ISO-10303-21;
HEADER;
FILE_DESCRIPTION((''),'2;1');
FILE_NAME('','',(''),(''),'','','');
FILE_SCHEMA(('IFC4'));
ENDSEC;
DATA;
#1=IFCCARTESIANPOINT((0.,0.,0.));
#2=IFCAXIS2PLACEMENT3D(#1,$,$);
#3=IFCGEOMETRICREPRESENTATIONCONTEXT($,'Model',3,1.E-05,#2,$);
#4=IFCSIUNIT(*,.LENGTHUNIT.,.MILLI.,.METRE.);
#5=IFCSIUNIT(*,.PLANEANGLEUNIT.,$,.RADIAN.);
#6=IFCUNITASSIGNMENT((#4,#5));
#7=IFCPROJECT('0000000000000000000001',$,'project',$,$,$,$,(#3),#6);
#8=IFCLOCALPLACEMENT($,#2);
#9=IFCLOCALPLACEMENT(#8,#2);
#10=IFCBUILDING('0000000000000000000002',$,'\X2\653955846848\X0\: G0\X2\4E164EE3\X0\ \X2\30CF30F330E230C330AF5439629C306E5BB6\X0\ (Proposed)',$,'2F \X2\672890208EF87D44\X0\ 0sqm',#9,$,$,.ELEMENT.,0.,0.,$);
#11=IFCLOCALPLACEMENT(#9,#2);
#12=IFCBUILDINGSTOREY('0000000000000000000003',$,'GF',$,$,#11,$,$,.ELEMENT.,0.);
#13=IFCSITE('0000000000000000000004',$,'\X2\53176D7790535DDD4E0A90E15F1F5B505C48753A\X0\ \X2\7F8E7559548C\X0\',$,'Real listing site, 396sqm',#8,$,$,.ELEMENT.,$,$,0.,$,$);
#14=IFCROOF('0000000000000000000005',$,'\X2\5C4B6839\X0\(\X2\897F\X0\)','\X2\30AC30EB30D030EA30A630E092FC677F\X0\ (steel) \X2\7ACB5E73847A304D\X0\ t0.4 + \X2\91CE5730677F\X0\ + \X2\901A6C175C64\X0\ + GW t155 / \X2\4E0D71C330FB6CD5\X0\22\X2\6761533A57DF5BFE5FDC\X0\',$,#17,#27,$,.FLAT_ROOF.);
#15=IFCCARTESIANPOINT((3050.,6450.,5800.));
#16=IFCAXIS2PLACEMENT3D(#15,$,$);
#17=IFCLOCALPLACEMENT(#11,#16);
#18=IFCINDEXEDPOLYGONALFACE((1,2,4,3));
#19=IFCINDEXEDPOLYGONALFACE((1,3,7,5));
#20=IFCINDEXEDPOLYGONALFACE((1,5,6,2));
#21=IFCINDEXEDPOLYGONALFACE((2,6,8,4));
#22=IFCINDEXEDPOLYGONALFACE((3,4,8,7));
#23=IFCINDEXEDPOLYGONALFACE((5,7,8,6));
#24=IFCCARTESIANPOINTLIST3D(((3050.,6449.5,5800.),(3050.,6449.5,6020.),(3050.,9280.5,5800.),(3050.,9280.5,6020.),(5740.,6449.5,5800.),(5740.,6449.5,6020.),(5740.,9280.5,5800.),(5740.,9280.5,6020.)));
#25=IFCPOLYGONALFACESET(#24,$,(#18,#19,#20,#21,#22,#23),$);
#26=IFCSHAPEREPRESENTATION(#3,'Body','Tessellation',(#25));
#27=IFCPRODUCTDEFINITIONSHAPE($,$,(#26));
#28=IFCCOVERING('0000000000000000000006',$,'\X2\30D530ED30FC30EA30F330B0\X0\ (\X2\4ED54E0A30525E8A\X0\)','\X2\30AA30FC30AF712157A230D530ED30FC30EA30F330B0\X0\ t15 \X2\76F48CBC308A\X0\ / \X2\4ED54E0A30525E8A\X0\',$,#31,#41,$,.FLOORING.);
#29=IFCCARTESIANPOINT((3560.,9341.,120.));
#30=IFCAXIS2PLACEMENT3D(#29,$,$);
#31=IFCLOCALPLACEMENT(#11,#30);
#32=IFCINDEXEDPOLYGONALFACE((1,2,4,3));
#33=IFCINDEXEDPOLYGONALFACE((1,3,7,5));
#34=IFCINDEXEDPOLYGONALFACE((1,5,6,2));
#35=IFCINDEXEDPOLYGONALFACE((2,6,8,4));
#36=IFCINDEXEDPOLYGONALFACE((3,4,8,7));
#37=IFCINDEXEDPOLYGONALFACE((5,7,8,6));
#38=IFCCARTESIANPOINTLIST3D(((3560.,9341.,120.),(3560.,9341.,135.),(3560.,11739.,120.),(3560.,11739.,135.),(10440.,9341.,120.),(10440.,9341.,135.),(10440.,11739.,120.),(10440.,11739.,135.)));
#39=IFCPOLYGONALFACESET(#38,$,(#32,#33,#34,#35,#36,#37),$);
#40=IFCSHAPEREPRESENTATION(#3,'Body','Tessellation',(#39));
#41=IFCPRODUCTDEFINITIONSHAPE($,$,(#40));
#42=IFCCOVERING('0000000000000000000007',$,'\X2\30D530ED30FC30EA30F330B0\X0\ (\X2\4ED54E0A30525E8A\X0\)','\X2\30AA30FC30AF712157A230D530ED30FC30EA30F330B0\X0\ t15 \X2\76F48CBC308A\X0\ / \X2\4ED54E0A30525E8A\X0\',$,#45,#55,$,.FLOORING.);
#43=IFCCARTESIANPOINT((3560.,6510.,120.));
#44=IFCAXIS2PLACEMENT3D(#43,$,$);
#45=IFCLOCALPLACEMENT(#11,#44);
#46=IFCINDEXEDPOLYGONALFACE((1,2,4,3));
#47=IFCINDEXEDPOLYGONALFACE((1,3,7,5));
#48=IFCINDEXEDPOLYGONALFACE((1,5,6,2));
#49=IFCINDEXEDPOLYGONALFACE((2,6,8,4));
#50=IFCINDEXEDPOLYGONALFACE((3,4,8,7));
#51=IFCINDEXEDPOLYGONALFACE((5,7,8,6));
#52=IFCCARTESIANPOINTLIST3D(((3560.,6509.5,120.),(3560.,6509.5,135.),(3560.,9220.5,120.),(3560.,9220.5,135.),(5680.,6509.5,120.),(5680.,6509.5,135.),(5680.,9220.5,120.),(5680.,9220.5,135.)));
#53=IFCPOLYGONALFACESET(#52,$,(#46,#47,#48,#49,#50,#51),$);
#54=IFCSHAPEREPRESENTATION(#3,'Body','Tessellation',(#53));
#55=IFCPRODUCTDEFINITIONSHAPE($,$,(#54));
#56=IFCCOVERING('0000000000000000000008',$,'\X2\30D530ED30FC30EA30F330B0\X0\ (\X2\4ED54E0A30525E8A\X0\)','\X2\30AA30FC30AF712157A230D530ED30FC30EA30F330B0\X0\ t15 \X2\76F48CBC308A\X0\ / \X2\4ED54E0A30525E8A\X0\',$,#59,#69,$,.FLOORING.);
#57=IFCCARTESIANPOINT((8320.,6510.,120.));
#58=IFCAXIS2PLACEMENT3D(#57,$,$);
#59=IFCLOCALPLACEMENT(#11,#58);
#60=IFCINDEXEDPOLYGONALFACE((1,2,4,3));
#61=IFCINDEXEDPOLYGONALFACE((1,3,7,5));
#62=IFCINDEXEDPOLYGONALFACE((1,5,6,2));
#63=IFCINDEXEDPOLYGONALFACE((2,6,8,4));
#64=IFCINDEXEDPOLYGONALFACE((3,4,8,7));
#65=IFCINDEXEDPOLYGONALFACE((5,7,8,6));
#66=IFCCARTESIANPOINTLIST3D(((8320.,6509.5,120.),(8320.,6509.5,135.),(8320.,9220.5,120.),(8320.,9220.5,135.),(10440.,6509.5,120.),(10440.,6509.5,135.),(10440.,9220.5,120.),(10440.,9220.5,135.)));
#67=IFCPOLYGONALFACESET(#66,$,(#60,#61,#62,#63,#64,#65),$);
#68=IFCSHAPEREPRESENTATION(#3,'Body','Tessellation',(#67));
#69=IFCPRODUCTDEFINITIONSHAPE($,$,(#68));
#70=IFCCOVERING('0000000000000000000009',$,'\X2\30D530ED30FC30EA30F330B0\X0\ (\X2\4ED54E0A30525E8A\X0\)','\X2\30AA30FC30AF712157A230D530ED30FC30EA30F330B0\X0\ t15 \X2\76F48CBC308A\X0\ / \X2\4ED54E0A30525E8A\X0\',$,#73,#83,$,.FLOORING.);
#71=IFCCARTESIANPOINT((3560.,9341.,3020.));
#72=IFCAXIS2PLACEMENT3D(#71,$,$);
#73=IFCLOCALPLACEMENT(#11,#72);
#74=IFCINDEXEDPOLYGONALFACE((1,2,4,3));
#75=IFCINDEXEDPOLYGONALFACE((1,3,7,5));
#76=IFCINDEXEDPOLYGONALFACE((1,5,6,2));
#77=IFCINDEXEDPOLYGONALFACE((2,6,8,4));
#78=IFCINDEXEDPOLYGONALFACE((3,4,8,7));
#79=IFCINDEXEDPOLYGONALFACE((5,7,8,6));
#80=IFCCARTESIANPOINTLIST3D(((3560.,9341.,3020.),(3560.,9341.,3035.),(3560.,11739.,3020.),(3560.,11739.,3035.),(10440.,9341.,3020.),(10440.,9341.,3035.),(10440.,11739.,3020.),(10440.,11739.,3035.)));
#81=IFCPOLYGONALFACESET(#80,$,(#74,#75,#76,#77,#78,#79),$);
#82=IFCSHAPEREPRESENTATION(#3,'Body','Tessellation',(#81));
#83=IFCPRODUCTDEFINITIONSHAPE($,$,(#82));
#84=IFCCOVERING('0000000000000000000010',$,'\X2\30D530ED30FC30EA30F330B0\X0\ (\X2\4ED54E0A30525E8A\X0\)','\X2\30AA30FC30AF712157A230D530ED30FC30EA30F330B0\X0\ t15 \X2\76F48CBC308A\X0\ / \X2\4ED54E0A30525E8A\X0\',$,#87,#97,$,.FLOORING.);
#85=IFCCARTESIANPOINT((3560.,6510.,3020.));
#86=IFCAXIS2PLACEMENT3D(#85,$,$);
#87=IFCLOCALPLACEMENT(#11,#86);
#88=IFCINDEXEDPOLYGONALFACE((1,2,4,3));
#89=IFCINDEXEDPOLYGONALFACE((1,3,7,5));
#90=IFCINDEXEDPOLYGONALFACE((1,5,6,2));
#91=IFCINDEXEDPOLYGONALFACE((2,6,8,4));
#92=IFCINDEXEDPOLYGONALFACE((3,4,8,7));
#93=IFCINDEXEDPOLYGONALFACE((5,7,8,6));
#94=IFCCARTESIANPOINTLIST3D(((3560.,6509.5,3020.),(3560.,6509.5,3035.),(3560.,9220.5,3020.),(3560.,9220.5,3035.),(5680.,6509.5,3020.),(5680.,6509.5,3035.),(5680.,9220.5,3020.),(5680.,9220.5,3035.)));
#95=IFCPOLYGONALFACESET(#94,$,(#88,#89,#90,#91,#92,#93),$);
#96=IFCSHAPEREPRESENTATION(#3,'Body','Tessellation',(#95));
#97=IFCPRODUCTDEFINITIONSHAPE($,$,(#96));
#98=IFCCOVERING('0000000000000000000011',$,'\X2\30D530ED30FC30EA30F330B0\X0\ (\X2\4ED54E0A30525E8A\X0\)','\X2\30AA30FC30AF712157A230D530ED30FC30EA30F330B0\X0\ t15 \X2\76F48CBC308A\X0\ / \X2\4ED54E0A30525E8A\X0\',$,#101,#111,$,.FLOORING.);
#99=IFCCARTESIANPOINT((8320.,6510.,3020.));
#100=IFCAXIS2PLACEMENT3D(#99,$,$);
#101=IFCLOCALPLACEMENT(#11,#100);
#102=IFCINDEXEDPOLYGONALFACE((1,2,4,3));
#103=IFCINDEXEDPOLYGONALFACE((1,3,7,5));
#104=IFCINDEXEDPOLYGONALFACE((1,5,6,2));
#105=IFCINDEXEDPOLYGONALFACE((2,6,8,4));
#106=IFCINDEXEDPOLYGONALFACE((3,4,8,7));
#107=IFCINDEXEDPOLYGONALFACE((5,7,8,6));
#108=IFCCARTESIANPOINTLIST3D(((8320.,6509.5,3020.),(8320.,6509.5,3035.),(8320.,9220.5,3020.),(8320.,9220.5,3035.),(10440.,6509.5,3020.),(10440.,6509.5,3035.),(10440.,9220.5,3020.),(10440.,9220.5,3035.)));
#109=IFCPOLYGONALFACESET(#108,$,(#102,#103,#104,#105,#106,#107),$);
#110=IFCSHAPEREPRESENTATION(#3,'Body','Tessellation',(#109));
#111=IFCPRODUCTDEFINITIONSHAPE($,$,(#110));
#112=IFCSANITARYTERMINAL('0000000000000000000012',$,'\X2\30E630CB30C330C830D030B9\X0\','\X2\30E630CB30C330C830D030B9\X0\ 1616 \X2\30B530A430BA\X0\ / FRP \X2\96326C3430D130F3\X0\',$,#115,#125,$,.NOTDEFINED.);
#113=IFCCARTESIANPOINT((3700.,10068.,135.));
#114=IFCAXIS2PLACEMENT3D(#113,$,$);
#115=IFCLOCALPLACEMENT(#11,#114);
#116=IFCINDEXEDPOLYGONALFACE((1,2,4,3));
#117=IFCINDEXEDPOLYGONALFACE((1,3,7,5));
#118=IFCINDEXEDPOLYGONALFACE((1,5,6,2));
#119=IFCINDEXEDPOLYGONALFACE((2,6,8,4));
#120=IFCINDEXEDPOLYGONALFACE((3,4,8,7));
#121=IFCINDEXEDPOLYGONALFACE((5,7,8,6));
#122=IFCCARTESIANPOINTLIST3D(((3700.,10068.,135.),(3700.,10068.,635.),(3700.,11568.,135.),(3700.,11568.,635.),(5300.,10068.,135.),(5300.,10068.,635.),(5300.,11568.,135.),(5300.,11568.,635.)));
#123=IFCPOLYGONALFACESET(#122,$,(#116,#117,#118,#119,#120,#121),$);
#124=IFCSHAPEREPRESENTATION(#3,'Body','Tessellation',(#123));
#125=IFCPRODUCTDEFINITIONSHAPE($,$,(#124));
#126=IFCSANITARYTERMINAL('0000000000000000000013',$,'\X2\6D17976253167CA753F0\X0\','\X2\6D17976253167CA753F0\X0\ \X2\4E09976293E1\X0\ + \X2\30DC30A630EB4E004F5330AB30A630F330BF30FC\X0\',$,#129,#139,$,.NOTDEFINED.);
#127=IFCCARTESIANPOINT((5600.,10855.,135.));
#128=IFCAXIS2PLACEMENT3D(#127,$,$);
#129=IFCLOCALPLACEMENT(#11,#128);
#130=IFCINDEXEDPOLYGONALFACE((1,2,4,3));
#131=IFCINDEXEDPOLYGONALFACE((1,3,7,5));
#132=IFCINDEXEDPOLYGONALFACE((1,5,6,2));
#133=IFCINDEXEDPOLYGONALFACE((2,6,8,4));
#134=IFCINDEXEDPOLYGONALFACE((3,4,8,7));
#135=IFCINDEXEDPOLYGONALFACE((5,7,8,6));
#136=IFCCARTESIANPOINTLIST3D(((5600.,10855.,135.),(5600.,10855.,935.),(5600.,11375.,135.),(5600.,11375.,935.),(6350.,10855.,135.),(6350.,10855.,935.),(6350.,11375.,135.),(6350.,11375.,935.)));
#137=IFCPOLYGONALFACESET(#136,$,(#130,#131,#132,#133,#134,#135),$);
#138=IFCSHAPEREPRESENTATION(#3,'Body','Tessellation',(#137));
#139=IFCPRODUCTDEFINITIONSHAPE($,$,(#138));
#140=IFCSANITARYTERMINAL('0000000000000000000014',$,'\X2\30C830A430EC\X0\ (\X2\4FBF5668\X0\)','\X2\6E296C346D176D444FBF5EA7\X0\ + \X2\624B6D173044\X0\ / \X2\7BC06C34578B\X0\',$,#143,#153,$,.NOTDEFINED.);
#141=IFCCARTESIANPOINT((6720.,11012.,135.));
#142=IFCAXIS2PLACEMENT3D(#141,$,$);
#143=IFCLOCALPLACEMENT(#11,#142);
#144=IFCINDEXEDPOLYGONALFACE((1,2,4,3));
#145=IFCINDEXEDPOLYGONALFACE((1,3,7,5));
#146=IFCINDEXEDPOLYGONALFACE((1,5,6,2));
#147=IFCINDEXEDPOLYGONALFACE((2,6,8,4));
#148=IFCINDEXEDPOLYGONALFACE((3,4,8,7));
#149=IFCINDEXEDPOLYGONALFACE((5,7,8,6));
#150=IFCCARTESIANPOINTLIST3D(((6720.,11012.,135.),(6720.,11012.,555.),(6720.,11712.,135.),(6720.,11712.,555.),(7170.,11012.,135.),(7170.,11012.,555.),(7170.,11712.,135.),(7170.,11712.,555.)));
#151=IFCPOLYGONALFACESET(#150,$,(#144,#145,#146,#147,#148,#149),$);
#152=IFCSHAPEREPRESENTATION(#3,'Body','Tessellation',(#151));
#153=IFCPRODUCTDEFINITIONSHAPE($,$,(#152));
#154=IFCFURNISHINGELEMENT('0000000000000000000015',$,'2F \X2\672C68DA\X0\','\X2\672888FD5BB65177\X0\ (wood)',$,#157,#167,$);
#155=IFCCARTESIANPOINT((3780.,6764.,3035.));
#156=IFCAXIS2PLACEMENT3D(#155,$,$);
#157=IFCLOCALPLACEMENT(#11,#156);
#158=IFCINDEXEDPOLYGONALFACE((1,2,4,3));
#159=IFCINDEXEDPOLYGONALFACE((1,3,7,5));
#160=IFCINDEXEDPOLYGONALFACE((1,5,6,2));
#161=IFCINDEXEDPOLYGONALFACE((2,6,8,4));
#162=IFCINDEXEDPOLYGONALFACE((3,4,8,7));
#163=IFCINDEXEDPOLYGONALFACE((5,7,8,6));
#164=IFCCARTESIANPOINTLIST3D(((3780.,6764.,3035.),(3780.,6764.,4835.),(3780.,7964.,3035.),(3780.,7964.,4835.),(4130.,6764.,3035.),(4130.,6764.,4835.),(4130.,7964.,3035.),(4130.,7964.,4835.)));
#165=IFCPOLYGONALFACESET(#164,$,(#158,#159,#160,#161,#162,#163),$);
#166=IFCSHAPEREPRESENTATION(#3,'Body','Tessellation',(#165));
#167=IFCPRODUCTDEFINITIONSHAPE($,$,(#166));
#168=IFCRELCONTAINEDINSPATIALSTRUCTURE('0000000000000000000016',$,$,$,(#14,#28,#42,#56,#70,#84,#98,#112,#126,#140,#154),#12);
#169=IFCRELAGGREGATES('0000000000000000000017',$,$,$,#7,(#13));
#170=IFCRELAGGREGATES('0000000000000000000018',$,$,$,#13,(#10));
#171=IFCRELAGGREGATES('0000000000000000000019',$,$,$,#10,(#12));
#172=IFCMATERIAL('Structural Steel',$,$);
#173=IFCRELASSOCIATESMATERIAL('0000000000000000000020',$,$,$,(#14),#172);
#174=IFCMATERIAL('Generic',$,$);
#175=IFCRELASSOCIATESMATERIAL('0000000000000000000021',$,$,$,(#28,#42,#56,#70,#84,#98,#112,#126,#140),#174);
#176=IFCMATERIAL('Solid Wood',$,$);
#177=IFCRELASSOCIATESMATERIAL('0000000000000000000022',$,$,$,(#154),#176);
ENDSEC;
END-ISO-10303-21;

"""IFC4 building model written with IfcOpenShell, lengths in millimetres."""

from ifc_helpers import new_model, si_unit, frame, frame_2d, origin, place, context, project, spatial, rectangle, extrude, material, element, save


model = new_model("IFC4")

# Units and contexts
model_context = context("Model", 3, precision=1e-05, world=origin())
ifc_project = project(units=[si_unit("LENGTHUNIT", "METRE", prefix="MILLI"), si_unit("PLANEANGLEUNIT", "RADIAN")], contexts=[model_context])

# Site, building, storey
site_placement = place(None, origin())
site = spatial("IfcSite", under=ifc_project, at=site_placement, Name="北海道川上郡弟子屈町 美留和", ObjectType="Real listing site, 396sqm", CompositionType="ELEMENT", RefElevation=0.0)
building_placement = place(site_placement, origin())
building = spatial("IfcBuilding", under=site, at=building_placement, Name="改善案: G0世代 ハンモック吹抜の家 (Proposed)", ObjectType="2F 木造軸組 0sqm", CompositionType="ELEMENT", ElevationOfRefHeight=0.0, ElevationOfTerrain=0.0)
storey_placement = place(building_placement, origin())
storey = spatial("IfcBuildingStorey", under=building, at=storey_placement, Name="GF", CompositionType="ELEMENT", Elevation=0.0)

# Shared definitions
ifc_material_1 = material(Name="Solid Wood")

# Shared definitions
ifc_material_2 = material(Name="Generic")

# Roof
ifc_material_3 = material(Name="Structural Steel")
roof_1_placement = place(storey_placement, frame((3050.0, 6450.0, 5800.0)))
element("IfcRoof", 1, at=roof_1_placement, inside=storey, material=ifc_material_3, Name="屋根(西)", Description="ガルバリウム鋼板 (steel) 立平葺き t0.4 + 野地板 + 通気層 + GW t155 / 不燃・法22条区域対応", PredefinedType="FLAT_ROOF", context=model_context, shape_type="SweptSolid", body=[
    extrude(rectangle(XDim=2690.0, YDim=2831.0, at=frame_2d((1345.0, 1415.0))), frame((3050.0, 6450.0, 5800.0)), (0.0, 0.0, 1.0), 220.0),
])

# Coverings
covering_1_placement = place(storey_placement, frame((3560.0, 9341.0, 120.0)))
element("IfcCovering", 2, at=covering_1_placement, inside=storey, material=ifc_material_2, Name="フローリング (仕上げ床)", Description="オーク無垢フローリング t15 直貼り / 仕上げ床", PredefinedType="FLOORING", context=model_context, shape_type="SweptSolid", body=[
    extrude(rectangle(XDim=6880.0, YDim=2398.0, at=frame_2d((3440.0, 1199.0))), frame((3560.0, 9341.0, 120.0)), (0.0, 0.0, 1.0), 15.0),
])
covering_2_placement = place(storey_placement, frame((3560.0, 6510.0, 120.0)))
element("IfcCovering", 3, at=covering_2_placement, inside=storey, material=ifc_material_2, Name="フローリング (仕上げ床)", Description="オーク無垢フローリング t15 直貼り / 仕上げ床", PredefinedType="FLOORING", context=model_context, shape_type="SweptSolid", body=[
    extrude(rectangle(XDim=2120.0, YDim=2711.0, at=frame_2d((1060.0, 1355.0))), frame((3560.0, 6510.0, 120.0)), (0.0, 0.0, 1.0), 15.0),
])
covering_3_placement = place(storey_placement, frame((8320.0, 6510.0, 120.0)))
element("IfcCovering", 4, at=covering_3_placement, inside=storey, material=ifc_material_2, Name="フローリング (仕上げ床)", Description="オーク無垢フローリング t15 直貼り / 仕上げ床", PredefinedType="FLOORING", context=model_context, shape_type="SweptSolid", body=[
    extrude(rectangle(XDim=2120.0, YDim=2711.0, at=frame_2d((1060.0, 1355.0))), frame((8320.0, 6510.0, 120.0)), (0.0, 0.0, 1.0), 15.0),
])
covering_4_placement = place(storey_placement, frame((3560.0, 9341.0, 3020.0)))
element("IfcCovering", 5, at=covering_4_placement, inside=storey, material=ifc_material_2, Name="フローリング (仕上げ床)", Description="オーク無垢フローリング t15 直貼り / 仕上げ床", PredefinedType="FLOORING", context=model_context, shape_type="SweptSolid", body=[
    extrude(rectangle(XDim=6880.0, YDim=2398.0, at=frame_2d((3440.0, 1199.0))), frame((3560.0, 9341.0, 3020.0)), (0.0, 0.0, 1.0), 15.0),
])
covering_5_placement = place(storey_placement, frame((3560.0, 6510.0, 3020.0)))
element("IfcCovering", 6, at=covering_5_placement, inside=storey, material=ifc_material_2, Name="フローリング (仕上げ床)", Description="オーク無垢フローリング t15 直貼り / 仕上げ床", PredefinedType="FLOORING", context=model_context, shape_type="SweptSolid", body=[
    extrude(rectangle(XDim=2120.0, YDim=2711.0, at=frame_2d((1060.0, 1355.0))), frame((3560.0, 6510.0, 3020.0)), (0.0, 0.0, 1.0), 15.0),
])
covering_6_placement = place(storey_placement, frame((8320.0, 6510.0, 3020.0)))
element("IfcCovering", 7, at=covering_6_placement, inside=storey, material=ifc_material_2, Name="フローリング (仕上げ床)", Description="オーク無垢フローリング t15 直貼り / 仕上げ床", PredefinedType="FLOORING", context=model_context, shape_type="SweptSolid", body=[
    extrude(rectangle(XDim=2120.0, YDim=2711.0, at=frame_2d((1060.0, 1355.0))), frame((8320.0, 6510.0, 3020.0)), (0.0, 0.0, 1.0), 15.0),
])

# Sanitary terminals
sanitary_terminal_1_placement = place(storey_placement, frame((3700.0, 10068.0, 135.0)))
element("IfcSanitaryTerminal", 8, at=sanitary_terminal_1_placement, inside=storey, material=ifc_material_2, Name="ユニットバス", Description="ユニットバス 1616 サイズ / FRP 防水パン", PredefinedType="NOTDEFINED", context=model_context, shape_type="SweptSolid", body=[
    extrude(rectangle(XDim=1600.0, YDim=1500.0, at=frame_2d((800.0, 750.0))), frame((3700.0, 10068.0, 135.0)), (0.0, 0.0, 1.0), 500.0),
])
sanitary_terminal_2_placement = place(storey_placement, frame((5600.0, 10855.0, 135.0)))
element("IfcSanitaryTerminal", 9, at=sanitary_terminal_2_placement, inside=storey, material=ifc_material_2, Name="洗面化粧台", Description="洗面化粧台 三面鏡 + ボウル一体カウンター", PredefinedType="NOTDEFINED", context=model_context, shape_type="SweptSolid", body=[
    extrude(rectangle(XDim=750.0, YDim=520.0, at=frame_2d((375.0, 260.0))), frame((5600.0, 10855.0, 135.0)), (0.0, 0.0, 1.0), 800.0),
])
sanitary_terminal_3_placement = place(storey_placement, frame((6720.0, 11012.0, 135.0)))
element("IfcSanitaryTerminal", 10, at=sanitary_terminal_3_placement, inside=storey, material=ifc_material_2, Name="トイレ (便器)", Description="温水洗浄便座 + 手洗い / 節水型", PredefinedType="NOTDEFINED", context=model_context, shape_type="SweptSolid", body=[
    extrude(rectangle(XDim=450.0, YDim=700.0, at=frame_2d((225.0, 350.0))), frame((6720.0, 11012.0, 135.0)), (0.0, 0.0, 1.0), 420.0),
])

# Furnishing element
furnishing_placement = place(storey_placement, frame((3780.0, 6764.0, 3035.0)))
element("IfcFurnishingElement", 11, at=furnishing_placement, inside=storey, material=ifc_material_1, Name="2F 本棚", Description="木製家具 (wood)", context=model_context, shape_type="SweptSolid", body=[
    extrude(rectangle(XDim=350.0, YDim=1200.0, at=frame_2d((175.0, 600.0))), frame((3780.0, 6764.0, 3035.0)), (0.0, 0.0, 1.0), 1800.0),
])

save(model, "model.ifc")
